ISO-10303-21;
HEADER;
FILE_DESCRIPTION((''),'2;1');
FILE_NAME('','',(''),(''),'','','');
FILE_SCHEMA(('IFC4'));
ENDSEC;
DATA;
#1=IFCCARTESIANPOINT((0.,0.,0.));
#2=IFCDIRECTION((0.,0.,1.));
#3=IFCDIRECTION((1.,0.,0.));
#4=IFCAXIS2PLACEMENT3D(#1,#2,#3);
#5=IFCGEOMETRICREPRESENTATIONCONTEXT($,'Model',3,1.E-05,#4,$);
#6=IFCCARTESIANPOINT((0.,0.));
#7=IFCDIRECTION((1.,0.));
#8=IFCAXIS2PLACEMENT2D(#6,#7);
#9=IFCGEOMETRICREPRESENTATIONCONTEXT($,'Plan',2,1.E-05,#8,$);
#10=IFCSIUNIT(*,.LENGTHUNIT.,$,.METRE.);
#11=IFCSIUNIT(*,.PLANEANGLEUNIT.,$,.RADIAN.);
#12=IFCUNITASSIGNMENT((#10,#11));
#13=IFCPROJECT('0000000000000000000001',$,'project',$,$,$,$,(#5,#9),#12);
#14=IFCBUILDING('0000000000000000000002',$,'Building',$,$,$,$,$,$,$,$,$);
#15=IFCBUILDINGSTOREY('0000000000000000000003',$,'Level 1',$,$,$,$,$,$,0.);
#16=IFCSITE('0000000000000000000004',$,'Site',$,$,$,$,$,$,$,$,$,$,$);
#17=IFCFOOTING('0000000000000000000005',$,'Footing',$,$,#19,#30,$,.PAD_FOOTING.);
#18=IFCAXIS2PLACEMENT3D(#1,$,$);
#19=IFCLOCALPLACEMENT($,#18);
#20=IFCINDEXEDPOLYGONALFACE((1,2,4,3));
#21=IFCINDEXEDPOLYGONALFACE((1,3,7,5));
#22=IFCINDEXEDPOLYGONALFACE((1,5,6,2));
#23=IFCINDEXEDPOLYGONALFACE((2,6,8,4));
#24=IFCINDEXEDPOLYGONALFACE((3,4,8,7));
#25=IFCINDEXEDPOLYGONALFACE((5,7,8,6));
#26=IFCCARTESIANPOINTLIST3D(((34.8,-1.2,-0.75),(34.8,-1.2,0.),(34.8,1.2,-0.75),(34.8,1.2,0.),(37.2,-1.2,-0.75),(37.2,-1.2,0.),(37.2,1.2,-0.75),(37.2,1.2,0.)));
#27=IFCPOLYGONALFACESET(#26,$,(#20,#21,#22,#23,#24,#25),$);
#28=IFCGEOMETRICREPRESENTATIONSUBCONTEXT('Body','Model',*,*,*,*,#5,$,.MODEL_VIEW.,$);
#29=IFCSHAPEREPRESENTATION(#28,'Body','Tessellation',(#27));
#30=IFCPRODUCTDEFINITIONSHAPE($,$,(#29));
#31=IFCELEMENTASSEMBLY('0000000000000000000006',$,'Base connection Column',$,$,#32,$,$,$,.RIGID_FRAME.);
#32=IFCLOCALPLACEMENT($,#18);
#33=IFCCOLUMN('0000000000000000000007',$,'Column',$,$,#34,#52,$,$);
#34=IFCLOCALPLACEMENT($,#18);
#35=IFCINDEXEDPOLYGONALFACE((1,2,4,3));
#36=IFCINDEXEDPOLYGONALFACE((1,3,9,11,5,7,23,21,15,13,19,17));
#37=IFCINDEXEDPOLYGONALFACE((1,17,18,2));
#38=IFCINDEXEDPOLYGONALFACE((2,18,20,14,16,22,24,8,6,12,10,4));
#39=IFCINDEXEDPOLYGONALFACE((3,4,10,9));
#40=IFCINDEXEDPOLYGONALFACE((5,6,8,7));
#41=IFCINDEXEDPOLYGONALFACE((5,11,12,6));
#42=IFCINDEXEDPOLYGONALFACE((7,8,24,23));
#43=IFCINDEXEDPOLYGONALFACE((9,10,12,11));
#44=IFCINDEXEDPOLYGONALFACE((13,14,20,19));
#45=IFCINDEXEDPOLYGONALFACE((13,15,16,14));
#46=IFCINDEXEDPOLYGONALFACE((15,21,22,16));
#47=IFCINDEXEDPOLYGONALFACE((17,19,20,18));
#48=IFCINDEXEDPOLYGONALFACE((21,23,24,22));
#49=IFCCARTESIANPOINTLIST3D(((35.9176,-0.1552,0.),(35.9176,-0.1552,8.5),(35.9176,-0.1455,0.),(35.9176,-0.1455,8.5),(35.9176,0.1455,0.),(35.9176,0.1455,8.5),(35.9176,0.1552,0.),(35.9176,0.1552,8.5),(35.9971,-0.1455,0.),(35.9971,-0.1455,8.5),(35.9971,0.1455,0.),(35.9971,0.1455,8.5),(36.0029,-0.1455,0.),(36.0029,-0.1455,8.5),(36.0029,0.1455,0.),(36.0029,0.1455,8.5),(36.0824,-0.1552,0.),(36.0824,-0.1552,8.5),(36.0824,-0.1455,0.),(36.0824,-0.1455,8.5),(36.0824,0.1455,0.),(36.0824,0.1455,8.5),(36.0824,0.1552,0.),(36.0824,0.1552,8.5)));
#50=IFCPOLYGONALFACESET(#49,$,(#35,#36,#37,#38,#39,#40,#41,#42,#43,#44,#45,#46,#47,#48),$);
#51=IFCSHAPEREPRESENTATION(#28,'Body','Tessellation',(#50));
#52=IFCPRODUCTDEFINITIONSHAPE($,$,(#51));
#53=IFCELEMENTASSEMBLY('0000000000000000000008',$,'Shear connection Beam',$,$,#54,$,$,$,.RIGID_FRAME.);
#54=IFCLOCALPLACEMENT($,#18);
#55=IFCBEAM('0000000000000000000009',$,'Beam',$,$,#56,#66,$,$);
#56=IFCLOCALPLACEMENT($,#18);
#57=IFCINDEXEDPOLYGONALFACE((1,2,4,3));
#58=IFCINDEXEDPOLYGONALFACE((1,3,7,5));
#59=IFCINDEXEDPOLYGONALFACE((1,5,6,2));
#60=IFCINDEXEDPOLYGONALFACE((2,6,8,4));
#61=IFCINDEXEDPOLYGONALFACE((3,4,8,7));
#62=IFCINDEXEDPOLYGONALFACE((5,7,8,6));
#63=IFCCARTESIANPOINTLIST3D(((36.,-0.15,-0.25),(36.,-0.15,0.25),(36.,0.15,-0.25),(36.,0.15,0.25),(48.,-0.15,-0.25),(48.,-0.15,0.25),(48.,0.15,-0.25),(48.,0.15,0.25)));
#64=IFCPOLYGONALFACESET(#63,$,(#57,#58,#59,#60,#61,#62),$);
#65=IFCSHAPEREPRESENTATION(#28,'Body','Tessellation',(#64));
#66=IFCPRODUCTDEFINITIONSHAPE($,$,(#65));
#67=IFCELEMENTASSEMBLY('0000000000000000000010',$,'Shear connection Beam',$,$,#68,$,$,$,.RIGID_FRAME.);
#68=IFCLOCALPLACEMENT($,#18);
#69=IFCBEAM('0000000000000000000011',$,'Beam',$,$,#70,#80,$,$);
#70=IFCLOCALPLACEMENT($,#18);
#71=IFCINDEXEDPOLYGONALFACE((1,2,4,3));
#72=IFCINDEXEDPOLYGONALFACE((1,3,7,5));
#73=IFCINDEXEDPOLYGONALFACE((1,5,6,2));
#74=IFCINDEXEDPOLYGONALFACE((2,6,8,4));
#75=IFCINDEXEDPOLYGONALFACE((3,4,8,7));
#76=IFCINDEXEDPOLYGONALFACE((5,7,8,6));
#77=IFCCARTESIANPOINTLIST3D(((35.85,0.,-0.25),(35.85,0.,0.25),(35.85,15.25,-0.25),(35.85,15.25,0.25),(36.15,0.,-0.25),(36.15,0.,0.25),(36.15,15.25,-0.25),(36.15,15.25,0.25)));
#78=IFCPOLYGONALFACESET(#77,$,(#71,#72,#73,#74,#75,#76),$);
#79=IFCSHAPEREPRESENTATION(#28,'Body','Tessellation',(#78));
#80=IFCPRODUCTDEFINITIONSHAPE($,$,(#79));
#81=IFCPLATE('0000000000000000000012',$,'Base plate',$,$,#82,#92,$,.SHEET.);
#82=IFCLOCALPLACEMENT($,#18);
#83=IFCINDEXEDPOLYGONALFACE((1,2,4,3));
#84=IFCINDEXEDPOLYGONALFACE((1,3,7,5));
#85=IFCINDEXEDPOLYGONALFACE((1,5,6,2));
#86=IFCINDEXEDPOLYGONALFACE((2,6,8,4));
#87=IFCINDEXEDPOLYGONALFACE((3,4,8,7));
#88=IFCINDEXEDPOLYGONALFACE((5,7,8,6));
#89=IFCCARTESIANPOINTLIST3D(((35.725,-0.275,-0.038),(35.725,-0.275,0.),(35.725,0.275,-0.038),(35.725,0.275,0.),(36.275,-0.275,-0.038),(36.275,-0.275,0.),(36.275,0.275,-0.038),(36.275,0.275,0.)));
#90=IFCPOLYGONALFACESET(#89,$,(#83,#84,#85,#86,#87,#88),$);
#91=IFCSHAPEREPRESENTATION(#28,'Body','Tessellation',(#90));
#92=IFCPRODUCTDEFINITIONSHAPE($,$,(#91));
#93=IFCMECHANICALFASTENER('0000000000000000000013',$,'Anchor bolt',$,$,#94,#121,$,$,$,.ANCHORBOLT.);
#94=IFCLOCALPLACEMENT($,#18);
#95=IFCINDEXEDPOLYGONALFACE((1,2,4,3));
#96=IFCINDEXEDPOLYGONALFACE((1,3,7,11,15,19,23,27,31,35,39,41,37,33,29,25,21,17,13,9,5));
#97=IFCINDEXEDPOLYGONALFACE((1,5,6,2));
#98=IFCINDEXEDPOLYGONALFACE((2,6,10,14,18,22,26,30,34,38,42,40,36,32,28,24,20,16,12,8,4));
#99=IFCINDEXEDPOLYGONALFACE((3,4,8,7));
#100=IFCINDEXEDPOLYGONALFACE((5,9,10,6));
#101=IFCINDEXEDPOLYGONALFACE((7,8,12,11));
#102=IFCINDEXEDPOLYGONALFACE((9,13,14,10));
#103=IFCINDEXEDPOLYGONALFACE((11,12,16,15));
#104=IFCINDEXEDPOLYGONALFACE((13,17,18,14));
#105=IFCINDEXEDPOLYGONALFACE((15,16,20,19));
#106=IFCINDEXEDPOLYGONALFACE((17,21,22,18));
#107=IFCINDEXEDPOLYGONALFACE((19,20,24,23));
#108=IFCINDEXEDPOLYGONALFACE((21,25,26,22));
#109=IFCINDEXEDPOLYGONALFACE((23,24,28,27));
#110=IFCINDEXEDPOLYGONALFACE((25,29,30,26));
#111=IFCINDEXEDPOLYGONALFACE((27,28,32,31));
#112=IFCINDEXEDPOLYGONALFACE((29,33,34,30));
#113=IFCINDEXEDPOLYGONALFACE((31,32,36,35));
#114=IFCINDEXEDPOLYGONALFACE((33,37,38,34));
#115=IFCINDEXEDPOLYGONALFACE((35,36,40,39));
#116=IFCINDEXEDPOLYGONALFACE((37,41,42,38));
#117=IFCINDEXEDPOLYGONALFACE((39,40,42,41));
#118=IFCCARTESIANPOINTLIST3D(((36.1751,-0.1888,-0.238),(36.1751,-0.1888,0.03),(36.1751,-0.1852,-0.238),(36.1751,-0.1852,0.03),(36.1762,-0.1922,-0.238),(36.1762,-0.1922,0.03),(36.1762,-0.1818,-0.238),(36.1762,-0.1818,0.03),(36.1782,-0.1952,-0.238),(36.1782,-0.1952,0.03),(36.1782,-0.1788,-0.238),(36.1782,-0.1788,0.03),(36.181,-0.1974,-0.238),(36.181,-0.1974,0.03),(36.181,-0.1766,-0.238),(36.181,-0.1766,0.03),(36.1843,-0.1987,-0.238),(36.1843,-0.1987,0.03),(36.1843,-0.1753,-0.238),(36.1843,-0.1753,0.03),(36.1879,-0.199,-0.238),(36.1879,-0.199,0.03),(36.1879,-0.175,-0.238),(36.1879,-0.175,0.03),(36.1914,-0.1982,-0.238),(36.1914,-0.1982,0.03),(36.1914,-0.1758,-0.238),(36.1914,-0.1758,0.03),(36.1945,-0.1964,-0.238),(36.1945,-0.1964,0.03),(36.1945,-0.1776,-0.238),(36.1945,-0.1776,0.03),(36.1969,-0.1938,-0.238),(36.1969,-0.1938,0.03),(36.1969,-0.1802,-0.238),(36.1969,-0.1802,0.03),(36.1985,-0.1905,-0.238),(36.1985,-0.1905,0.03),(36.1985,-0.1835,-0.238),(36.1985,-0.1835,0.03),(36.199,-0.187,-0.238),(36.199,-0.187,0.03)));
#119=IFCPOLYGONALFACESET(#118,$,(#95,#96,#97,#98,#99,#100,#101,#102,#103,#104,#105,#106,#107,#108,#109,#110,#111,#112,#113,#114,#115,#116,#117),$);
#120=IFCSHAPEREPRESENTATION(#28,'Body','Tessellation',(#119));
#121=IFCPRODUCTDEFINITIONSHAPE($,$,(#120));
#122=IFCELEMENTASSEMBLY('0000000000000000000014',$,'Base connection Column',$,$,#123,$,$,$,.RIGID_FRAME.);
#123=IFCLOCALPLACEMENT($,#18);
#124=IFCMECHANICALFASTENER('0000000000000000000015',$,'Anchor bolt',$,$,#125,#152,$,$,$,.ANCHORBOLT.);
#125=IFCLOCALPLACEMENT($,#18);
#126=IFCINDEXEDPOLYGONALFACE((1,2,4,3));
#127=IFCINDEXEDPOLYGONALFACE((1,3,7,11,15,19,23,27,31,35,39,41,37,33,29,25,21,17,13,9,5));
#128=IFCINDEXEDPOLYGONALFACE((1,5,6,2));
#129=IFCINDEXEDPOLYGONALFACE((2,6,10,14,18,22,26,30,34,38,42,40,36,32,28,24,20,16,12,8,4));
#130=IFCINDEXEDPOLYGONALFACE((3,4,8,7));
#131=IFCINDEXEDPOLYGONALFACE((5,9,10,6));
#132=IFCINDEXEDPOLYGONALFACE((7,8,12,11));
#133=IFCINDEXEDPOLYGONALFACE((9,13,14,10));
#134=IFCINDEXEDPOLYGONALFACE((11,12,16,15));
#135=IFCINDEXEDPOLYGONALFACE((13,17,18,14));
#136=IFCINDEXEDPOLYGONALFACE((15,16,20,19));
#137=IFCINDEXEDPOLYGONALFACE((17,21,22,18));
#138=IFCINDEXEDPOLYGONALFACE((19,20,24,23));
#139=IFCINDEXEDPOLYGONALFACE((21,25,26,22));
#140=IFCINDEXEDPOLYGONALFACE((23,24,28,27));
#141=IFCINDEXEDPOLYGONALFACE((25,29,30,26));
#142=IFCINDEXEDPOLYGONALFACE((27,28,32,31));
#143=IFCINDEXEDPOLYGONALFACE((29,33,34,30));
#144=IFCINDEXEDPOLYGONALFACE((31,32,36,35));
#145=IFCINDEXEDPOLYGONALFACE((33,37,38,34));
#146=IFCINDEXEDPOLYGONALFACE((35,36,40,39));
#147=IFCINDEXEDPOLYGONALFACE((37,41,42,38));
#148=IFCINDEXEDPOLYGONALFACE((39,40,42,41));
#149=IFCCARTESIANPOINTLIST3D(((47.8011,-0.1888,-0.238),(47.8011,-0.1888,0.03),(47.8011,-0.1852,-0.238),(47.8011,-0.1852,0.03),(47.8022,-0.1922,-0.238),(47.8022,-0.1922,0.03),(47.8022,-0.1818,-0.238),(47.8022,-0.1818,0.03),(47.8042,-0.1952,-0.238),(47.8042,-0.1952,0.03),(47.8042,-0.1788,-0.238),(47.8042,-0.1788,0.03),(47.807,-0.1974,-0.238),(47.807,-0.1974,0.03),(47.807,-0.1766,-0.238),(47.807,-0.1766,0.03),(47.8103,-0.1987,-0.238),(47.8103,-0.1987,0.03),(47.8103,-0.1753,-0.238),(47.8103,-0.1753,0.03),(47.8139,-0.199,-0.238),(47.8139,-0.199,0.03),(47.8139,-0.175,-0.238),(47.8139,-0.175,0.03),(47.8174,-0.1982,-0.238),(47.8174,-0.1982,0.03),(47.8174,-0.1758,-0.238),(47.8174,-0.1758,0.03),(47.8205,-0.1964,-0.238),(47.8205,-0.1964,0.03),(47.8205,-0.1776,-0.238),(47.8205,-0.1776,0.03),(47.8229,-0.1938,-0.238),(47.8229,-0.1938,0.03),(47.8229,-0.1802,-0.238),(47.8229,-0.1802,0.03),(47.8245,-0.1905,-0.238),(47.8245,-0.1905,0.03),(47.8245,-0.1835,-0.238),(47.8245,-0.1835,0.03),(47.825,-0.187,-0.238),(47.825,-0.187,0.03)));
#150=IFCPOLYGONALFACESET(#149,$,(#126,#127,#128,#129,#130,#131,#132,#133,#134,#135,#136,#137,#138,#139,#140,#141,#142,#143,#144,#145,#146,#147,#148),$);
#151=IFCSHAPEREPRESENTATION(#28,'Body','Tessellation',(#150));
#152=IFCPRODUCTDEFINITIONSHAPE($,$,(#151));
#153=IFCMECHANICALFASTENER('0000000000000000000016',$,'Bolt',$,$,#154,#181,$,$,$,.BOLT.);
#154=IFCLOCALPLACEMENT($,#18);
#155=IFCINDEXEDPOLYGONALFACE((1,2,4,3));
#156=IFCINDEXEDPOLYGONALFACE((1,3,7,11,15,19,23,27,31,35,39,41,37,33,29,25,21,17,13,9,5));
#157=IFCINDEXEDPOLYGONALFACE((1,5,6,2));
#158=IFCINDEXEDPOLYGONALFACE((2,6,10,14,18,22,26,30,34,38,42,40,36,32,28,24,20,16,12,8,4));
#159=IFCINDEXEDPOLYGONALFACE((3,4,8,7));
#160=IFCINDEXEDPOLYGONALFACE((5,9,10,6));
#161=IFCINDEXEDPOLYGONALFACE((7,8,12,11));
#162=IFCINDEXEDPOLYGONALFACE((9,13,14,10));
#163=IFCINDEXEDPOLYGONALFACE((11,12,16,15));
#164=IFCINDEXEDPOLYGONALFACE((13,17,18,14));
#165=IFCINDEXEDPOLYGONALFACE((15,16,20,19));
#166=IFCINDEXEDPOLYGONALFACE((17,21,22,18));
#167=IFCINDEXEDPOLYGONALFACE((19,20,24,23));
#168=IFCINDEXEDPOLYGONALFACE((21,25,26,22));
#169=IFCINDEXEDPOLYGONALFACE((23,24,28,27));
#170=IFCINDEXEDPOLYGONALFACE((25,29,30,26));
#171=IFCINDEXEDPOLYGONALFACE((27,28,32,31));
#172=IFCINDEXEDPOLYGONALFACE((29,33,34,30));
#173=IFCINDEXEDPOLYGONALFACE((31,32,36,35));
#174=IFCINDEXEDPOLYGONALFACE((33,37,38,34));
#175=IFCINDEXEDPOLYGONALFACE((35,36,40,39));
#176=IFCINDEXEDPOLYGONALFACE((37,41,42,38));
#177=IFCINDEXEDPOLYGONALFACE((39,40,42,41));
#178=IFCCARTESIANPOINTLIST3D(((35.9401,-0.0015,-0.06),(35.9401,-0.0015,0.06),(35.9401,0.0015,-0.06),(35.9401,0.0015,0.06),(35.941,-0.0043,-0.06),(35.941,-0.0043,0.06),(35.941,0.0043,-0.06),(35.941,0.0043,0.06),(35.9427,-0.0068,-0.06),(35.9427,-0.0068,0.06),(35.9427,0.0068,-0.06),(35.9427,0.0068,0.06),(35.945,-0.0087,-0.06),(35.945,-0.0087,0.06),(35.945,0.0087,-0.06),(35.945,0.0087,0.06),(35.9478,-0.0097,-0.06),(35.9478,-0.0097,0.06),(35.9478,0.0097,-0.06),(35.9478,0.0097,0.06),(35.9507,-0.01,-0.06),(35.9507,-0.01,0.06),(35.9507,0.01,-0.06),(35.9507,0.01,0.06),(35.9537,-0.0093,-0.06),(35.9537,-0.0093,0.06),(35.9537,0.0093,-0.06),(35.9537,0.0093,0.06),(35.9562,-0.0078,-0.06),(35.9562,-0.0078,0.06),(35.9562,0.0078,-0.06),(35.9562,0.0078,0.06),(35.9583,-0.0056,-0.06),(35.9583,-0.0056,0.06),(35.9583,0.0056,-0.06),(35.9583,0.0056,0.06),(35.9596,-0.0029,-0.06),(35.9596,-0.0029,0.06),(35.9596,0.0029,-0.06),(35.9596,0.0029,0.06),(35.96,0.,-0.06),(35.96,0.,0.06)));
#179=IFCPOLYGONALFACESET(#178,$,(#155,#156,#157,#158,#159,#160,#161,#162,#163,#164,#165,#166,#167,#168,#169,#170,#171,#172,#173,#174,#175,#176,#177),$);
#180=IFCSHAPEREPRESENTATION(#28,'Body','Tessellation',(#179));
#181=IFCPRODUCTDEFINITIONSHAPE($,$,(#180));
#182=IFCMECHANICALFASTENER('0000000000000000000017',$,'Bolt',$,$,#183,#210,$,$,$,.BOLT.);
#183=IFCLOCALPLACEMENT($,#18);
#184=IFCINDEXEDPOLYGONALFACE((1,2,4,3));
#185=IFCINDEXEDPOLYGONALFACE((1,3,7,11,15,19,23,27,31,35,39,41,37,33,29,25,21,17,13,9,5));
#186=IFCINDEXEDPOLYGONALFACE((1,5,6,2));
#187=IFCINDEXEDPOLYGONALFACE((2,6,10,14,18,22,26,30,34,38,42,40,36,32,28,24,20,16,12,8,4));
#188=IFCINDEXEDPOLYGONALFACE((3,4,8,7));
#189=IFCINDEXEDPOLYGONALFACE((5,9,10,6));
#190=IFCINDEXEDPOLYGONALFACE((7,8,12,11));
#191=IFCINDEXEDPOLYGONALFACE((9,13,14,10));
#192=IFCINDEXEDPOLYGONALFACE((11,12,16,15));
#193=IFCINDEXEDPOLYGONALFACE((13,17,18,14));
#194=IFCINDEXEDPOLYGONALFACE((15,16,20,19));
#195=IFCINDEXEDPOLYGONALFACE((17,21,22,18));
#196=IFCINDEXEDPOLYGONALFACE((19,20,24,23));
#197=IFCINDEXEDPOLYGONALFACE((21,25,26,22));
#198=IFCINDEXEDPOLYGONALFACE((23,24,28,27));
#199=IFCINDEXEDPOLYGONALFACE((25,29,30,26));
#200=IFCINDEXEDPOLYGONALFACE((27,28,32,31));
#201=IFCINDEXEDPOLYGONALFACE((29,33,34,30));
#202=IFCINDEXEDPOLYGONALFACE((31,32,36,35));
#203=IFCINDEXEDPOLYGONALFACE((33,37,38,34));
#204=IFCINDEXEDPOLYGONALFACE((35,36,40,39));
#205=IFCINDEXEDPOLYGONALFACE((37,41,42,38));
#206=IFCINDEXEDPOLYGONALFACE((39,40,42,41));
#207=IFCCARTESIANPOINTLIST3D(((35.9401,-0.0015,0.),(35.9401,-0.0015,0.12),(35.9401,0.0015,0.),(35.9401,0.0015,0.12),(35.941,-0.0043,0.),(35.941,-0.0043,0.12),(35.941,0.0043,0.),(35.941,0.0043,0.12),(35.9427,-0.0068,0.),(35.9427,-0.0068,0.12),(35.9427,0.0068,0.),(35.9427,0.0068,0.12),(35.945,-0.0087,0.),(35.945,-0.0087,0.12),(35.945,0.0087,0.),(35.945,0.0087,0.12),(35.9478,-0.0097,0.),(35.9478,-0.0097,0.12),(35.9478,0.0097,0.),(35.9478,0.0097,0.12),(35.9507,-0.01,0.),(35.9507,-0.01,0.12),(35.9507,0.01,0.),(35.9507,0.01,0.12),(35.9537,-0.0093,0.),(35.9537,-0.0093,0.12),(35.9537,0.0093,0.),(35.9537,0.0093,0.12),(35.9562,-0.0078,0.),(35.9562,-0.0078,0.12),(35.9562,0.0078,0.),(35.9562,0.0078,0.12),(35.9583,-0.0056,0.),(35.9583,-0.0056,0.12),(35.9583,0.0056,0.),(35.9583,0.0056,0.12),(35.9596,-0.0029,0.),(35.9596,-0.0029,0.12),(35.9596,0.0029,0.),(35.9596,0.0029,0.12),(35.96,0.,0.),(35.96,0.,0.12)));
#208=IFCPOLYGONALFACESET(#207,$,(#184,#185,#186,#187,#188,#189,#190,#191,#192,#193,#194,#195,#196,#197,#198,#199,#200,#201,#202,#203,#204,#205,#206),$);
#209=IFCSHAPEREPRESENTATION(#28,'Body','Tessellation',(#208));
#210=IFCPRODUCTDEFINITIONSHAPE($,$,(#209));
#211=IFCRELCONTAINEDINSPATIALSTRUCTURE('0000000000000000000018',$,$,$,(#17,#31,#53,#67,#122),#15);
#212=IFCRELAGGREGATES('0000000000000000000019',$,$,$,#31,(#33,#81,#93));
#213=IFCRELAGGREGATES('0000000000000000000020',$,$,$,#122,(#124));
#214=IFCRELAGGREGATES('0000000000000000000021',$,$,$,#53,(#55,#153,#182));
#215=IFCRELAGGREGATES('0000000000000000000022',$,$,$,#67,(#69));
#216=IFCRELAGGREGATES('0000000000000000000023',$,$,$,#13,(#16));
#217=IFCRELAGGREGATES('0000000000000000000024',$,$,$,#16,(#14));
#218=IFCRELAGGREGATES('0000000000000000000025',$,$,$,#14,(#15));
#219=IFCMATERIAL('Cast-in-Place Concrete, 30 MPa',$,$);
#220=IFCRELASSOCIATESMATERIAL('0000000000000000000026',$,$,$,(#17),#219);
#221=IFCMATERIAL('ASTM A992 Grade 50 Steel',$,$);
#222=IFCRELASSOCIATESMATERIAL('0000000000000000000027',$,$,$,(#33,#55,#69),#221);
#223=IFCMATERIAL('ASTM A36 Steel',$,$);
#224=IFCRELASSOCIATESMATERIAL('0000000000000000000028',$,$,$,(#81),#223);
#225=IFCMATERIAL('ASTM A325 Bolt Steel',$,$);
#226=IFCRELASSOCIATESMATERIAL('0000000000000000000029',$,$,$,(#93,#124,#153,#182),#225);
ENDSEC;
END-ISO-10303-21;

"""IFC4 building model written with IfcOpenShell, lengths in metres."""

from ifc_helpers import new_model, si_unit, frame, origin_with_axes, origin_2d, origin_2d_with_axis, place, context, subcontext, project, spatial, rectangle, circle, i_section, extrude, material, element, aggregate, save


model = new_model("IFC4")

# Units and contexts
model_context = context("Model", 3, precision=1e-05, world=origin_with_axes())
plan_context = context("Plan", 2, precision=1e-05, world=origin_2d_with_axis())
body_context = subcontext(model_context, "Body", "Model", "MODEL_VIEW")
ifc_project = project(units=[si_unit("LENGTHUNIT", "METRE"), si_unit("PLANEANGLEUNIT", "RADIAN")], contexts=[model_context, plan_context])

# Site, building, storey
site = spatial("IfcSite", under=ifc_project, Name="Site")
building = spatial("IfcBuilding", under=site, Name="Building")
storey = spatial("IfcBuildingStorey", under=building, Name="Level 1", Elevation=0.0)

# Footing
ifc_material_1 = material(Name="Cast-in-Place Concrete, 30 MPa")
footing_placement = place(None, frame((36.0, 0.0, -0.75), z_axis=(0.0, 0.0, 1.0), x_axis=(1.0, 0.0, 0.0)))
element("IfcFooting", 1, at=footing_placement, inside=storey, material=ifc_material_1, Name="Footing", PredefinedType="PAD_FOOTING", context=body_context, shape_type="SweptSolid", body=[
    extrude(rectangle(XDim=2.4, YDim=2.4, at=origin_2d_with_axis()), origin_with_axes(), (0.0, 0.0, 1.0), 0.75),
])

# Element assembly, column
assembly_1 = element("IfcElementAssembly", 2, inside=storey, Name="Base connection Column", PredefinedType="RIGID_FRAME")
ifc_material_2 = material(Name="ASTM A992 Grade 50 Steel")
column_placement = place(None, frame((36.0, 0.0, 0.0), z_axis=(0.0, 0.0, 1.0), x_axis=(1.0, 0.0, 0.0)))
column = element("IfcColumn", 3, at=column_placement, material=ifc_material_2, Name="Column", context=body_context, shape_type="SweptSolid", body=[
    extrude(i_section(OverallWidth=0.1648, OverallDepth=0.3104, WebThickness=0.0058, FlangeThickness=0.0097, at=origin_2d_with_axis()), origin_with_axes(), (0.0, 0.0, 1.0), 8.5),
])

# Element assemblies, beams
assembly_2 = element("IfcElementAssembly", 4, inside=storey, Name="Shear connection Beam", PredefinedType="RIGID_FRAME")
beam_1_placement = place(None, frame((36.0, 0.0, 0.0), z_axis=(1.0, 0.0, 0.0), x_axis=(0.0, 1.0, 0.0)))
beam_1 = element("IfcBeam", 5, at=beam_1_placement, material=ifc_material_2, Name="Beam", context=body_context, shape_type="SweptSolid", body=[
    extrude(rectangle(XDim=0.3, YDim=0.5, at=origin_2d_with_axis()), origin_with_axes(), (0.0, 0.0, 1.0), 12.0),
])
assembly_3 = element("IfcElementAssembly", 6, inside=storey, Name="Shear connection Beam", PredefinedType="RIGID_FRAME")
beam_2_placement = place(None, frame((36.0, 0.0, 0.0), z_axis=(0.0, 1.0, 0.0), x_axis=(-1.0, 0.0, 0.0)))
beam_2 = element("IfcBeam", 7, at=beam_2_placement, material=ifc_material_2, Name="Beam", context=body_context, shape_type="SweptSolid", body=[
    extrude(rectangle(XDim=0.3, YDim=0.5, at=origin_2d_with_axis()), origin_with_axes(), (0.0, 0.0, 1.0), 15.25),
])

# Plate
ifc_material_3 = material(Name="ASTM A36 Steel")
plate_placement = place(None, frame((36.0, 0.0, -0.038), z_axis=(0.0, 0.0, 1.0), x_axis=(1.0, 0.0, 0.0)))
plate = element("IfcPlate", 8, at=plate_placement, material=ifc_material_3, Name="Base plate", PredefinedType="SHEET", context=body_context, shape_type="SweptSolid", body=[
    extrude(rectangle(XDim=0.55, YDim=0.55, at=origin_2d_with_axis()), origin_with_axes(), (0.0, 0.0, 1.0), 0.038),
])

# Mechanical fastener
ifc_material_4 = material(Name="ASTM A325 Bolt Steel")
mechanical_fastener_1_placement = place(None, frame((36.187, -0.187, -0.238), z_axis=(0.0, 0.0, 1.0), x_axis=(1.0, 0.0, 0.0)))
mechanical_fastener_1 = element("IfcMechanicalFastener", 9, at=mechanical_fastener_1_placement, material=ifc_material_4, Name="Anchor bolt", PredefinedType="ANCHORBOLT", context=body_context, shape_type="SweptSolid", body=[
    extrude(circle(Radius=0.012, at=origin_2d()), origin_with_axes(), (0.0, 0.0, 1.0), 0.268),
])
aggregate(assembly_1, [column, plate, mechanical_fastener_1])

# Element assembly, mechanical fastener
assembly_4 = element("IfcElementAssembly", 10, inside=storey, Name="Base connection Column", PredefinedType="RIGID_FRAME")
mechanical_fastener_2_placement = place(None, frame((47.813, -0.187, -0.238), z_axis=(0.0, 0.0, 1.0), x_axis=(1.0, 0.0, 0.0)))
mechanical_fastener_2 = element("IfcMechanicalFastener", 11, at=mechanical_fastener_2_placement, material=ifc_material_4, Name="Anchor bolt", PredefinedType="ANCHORBOLT", context=body_context, shape_type="SweptSolid", body=[
    extrude(circle(Radius=0.012, at=origin_2d()), origin_with_axes(), (0.0, 0.0, 1.0), 0.268),
])
aggregate(assembly_4, [mechanical_fastener_2])

# Mechanical fasteners
mechanical_fastener_3_placement = place(None, frame((35.95, 0.0, -0.06), z_axis=(0.0, 0.0, 1.0), x_axis=(1.0, 0.0, 0.0)))
mechanical_fastener_3 = element("IfcMechanicalFastener", 12, at=mechanical_fastener_3_placement, material=ifc_material_4, Name="Bolt", PredefinedType="BOLT", context=body_context, shape_type="SweptSolid", body=[
    extrude(circle(Radius=0.01, at=origin_2d()), origin_with_axes(), (0.0, 0.0, 1.0), 0.12),
])
mechanical_fastener_4_placement = place(None, frame((35.95, 0.0, 0.0), z_axis=(0.0, 0.0, 1.0), x_axis=(1.0, 0.0, 0.0)))
mechanical_fastener_4 = element("IfcMechanicalFastener", 13, at=mechanical_fastener_4_placement, material=ifc_material_4, Name="Bolt", PredefinedType="BOLT", context=body_context, shape_type="SweptSolid", body=[
    extrude(circle(Radius=0.01, at=origin_2d()), origin_with_axes(), (0.0, 0.0, 1.0), 0.12),
])
aggregate(assembly_2, [beam_1, mechanical_fastener_3, mechanical_fastener_4])
aggregate(assembly_3, [beam_2])

save(model, "model.ifc")
